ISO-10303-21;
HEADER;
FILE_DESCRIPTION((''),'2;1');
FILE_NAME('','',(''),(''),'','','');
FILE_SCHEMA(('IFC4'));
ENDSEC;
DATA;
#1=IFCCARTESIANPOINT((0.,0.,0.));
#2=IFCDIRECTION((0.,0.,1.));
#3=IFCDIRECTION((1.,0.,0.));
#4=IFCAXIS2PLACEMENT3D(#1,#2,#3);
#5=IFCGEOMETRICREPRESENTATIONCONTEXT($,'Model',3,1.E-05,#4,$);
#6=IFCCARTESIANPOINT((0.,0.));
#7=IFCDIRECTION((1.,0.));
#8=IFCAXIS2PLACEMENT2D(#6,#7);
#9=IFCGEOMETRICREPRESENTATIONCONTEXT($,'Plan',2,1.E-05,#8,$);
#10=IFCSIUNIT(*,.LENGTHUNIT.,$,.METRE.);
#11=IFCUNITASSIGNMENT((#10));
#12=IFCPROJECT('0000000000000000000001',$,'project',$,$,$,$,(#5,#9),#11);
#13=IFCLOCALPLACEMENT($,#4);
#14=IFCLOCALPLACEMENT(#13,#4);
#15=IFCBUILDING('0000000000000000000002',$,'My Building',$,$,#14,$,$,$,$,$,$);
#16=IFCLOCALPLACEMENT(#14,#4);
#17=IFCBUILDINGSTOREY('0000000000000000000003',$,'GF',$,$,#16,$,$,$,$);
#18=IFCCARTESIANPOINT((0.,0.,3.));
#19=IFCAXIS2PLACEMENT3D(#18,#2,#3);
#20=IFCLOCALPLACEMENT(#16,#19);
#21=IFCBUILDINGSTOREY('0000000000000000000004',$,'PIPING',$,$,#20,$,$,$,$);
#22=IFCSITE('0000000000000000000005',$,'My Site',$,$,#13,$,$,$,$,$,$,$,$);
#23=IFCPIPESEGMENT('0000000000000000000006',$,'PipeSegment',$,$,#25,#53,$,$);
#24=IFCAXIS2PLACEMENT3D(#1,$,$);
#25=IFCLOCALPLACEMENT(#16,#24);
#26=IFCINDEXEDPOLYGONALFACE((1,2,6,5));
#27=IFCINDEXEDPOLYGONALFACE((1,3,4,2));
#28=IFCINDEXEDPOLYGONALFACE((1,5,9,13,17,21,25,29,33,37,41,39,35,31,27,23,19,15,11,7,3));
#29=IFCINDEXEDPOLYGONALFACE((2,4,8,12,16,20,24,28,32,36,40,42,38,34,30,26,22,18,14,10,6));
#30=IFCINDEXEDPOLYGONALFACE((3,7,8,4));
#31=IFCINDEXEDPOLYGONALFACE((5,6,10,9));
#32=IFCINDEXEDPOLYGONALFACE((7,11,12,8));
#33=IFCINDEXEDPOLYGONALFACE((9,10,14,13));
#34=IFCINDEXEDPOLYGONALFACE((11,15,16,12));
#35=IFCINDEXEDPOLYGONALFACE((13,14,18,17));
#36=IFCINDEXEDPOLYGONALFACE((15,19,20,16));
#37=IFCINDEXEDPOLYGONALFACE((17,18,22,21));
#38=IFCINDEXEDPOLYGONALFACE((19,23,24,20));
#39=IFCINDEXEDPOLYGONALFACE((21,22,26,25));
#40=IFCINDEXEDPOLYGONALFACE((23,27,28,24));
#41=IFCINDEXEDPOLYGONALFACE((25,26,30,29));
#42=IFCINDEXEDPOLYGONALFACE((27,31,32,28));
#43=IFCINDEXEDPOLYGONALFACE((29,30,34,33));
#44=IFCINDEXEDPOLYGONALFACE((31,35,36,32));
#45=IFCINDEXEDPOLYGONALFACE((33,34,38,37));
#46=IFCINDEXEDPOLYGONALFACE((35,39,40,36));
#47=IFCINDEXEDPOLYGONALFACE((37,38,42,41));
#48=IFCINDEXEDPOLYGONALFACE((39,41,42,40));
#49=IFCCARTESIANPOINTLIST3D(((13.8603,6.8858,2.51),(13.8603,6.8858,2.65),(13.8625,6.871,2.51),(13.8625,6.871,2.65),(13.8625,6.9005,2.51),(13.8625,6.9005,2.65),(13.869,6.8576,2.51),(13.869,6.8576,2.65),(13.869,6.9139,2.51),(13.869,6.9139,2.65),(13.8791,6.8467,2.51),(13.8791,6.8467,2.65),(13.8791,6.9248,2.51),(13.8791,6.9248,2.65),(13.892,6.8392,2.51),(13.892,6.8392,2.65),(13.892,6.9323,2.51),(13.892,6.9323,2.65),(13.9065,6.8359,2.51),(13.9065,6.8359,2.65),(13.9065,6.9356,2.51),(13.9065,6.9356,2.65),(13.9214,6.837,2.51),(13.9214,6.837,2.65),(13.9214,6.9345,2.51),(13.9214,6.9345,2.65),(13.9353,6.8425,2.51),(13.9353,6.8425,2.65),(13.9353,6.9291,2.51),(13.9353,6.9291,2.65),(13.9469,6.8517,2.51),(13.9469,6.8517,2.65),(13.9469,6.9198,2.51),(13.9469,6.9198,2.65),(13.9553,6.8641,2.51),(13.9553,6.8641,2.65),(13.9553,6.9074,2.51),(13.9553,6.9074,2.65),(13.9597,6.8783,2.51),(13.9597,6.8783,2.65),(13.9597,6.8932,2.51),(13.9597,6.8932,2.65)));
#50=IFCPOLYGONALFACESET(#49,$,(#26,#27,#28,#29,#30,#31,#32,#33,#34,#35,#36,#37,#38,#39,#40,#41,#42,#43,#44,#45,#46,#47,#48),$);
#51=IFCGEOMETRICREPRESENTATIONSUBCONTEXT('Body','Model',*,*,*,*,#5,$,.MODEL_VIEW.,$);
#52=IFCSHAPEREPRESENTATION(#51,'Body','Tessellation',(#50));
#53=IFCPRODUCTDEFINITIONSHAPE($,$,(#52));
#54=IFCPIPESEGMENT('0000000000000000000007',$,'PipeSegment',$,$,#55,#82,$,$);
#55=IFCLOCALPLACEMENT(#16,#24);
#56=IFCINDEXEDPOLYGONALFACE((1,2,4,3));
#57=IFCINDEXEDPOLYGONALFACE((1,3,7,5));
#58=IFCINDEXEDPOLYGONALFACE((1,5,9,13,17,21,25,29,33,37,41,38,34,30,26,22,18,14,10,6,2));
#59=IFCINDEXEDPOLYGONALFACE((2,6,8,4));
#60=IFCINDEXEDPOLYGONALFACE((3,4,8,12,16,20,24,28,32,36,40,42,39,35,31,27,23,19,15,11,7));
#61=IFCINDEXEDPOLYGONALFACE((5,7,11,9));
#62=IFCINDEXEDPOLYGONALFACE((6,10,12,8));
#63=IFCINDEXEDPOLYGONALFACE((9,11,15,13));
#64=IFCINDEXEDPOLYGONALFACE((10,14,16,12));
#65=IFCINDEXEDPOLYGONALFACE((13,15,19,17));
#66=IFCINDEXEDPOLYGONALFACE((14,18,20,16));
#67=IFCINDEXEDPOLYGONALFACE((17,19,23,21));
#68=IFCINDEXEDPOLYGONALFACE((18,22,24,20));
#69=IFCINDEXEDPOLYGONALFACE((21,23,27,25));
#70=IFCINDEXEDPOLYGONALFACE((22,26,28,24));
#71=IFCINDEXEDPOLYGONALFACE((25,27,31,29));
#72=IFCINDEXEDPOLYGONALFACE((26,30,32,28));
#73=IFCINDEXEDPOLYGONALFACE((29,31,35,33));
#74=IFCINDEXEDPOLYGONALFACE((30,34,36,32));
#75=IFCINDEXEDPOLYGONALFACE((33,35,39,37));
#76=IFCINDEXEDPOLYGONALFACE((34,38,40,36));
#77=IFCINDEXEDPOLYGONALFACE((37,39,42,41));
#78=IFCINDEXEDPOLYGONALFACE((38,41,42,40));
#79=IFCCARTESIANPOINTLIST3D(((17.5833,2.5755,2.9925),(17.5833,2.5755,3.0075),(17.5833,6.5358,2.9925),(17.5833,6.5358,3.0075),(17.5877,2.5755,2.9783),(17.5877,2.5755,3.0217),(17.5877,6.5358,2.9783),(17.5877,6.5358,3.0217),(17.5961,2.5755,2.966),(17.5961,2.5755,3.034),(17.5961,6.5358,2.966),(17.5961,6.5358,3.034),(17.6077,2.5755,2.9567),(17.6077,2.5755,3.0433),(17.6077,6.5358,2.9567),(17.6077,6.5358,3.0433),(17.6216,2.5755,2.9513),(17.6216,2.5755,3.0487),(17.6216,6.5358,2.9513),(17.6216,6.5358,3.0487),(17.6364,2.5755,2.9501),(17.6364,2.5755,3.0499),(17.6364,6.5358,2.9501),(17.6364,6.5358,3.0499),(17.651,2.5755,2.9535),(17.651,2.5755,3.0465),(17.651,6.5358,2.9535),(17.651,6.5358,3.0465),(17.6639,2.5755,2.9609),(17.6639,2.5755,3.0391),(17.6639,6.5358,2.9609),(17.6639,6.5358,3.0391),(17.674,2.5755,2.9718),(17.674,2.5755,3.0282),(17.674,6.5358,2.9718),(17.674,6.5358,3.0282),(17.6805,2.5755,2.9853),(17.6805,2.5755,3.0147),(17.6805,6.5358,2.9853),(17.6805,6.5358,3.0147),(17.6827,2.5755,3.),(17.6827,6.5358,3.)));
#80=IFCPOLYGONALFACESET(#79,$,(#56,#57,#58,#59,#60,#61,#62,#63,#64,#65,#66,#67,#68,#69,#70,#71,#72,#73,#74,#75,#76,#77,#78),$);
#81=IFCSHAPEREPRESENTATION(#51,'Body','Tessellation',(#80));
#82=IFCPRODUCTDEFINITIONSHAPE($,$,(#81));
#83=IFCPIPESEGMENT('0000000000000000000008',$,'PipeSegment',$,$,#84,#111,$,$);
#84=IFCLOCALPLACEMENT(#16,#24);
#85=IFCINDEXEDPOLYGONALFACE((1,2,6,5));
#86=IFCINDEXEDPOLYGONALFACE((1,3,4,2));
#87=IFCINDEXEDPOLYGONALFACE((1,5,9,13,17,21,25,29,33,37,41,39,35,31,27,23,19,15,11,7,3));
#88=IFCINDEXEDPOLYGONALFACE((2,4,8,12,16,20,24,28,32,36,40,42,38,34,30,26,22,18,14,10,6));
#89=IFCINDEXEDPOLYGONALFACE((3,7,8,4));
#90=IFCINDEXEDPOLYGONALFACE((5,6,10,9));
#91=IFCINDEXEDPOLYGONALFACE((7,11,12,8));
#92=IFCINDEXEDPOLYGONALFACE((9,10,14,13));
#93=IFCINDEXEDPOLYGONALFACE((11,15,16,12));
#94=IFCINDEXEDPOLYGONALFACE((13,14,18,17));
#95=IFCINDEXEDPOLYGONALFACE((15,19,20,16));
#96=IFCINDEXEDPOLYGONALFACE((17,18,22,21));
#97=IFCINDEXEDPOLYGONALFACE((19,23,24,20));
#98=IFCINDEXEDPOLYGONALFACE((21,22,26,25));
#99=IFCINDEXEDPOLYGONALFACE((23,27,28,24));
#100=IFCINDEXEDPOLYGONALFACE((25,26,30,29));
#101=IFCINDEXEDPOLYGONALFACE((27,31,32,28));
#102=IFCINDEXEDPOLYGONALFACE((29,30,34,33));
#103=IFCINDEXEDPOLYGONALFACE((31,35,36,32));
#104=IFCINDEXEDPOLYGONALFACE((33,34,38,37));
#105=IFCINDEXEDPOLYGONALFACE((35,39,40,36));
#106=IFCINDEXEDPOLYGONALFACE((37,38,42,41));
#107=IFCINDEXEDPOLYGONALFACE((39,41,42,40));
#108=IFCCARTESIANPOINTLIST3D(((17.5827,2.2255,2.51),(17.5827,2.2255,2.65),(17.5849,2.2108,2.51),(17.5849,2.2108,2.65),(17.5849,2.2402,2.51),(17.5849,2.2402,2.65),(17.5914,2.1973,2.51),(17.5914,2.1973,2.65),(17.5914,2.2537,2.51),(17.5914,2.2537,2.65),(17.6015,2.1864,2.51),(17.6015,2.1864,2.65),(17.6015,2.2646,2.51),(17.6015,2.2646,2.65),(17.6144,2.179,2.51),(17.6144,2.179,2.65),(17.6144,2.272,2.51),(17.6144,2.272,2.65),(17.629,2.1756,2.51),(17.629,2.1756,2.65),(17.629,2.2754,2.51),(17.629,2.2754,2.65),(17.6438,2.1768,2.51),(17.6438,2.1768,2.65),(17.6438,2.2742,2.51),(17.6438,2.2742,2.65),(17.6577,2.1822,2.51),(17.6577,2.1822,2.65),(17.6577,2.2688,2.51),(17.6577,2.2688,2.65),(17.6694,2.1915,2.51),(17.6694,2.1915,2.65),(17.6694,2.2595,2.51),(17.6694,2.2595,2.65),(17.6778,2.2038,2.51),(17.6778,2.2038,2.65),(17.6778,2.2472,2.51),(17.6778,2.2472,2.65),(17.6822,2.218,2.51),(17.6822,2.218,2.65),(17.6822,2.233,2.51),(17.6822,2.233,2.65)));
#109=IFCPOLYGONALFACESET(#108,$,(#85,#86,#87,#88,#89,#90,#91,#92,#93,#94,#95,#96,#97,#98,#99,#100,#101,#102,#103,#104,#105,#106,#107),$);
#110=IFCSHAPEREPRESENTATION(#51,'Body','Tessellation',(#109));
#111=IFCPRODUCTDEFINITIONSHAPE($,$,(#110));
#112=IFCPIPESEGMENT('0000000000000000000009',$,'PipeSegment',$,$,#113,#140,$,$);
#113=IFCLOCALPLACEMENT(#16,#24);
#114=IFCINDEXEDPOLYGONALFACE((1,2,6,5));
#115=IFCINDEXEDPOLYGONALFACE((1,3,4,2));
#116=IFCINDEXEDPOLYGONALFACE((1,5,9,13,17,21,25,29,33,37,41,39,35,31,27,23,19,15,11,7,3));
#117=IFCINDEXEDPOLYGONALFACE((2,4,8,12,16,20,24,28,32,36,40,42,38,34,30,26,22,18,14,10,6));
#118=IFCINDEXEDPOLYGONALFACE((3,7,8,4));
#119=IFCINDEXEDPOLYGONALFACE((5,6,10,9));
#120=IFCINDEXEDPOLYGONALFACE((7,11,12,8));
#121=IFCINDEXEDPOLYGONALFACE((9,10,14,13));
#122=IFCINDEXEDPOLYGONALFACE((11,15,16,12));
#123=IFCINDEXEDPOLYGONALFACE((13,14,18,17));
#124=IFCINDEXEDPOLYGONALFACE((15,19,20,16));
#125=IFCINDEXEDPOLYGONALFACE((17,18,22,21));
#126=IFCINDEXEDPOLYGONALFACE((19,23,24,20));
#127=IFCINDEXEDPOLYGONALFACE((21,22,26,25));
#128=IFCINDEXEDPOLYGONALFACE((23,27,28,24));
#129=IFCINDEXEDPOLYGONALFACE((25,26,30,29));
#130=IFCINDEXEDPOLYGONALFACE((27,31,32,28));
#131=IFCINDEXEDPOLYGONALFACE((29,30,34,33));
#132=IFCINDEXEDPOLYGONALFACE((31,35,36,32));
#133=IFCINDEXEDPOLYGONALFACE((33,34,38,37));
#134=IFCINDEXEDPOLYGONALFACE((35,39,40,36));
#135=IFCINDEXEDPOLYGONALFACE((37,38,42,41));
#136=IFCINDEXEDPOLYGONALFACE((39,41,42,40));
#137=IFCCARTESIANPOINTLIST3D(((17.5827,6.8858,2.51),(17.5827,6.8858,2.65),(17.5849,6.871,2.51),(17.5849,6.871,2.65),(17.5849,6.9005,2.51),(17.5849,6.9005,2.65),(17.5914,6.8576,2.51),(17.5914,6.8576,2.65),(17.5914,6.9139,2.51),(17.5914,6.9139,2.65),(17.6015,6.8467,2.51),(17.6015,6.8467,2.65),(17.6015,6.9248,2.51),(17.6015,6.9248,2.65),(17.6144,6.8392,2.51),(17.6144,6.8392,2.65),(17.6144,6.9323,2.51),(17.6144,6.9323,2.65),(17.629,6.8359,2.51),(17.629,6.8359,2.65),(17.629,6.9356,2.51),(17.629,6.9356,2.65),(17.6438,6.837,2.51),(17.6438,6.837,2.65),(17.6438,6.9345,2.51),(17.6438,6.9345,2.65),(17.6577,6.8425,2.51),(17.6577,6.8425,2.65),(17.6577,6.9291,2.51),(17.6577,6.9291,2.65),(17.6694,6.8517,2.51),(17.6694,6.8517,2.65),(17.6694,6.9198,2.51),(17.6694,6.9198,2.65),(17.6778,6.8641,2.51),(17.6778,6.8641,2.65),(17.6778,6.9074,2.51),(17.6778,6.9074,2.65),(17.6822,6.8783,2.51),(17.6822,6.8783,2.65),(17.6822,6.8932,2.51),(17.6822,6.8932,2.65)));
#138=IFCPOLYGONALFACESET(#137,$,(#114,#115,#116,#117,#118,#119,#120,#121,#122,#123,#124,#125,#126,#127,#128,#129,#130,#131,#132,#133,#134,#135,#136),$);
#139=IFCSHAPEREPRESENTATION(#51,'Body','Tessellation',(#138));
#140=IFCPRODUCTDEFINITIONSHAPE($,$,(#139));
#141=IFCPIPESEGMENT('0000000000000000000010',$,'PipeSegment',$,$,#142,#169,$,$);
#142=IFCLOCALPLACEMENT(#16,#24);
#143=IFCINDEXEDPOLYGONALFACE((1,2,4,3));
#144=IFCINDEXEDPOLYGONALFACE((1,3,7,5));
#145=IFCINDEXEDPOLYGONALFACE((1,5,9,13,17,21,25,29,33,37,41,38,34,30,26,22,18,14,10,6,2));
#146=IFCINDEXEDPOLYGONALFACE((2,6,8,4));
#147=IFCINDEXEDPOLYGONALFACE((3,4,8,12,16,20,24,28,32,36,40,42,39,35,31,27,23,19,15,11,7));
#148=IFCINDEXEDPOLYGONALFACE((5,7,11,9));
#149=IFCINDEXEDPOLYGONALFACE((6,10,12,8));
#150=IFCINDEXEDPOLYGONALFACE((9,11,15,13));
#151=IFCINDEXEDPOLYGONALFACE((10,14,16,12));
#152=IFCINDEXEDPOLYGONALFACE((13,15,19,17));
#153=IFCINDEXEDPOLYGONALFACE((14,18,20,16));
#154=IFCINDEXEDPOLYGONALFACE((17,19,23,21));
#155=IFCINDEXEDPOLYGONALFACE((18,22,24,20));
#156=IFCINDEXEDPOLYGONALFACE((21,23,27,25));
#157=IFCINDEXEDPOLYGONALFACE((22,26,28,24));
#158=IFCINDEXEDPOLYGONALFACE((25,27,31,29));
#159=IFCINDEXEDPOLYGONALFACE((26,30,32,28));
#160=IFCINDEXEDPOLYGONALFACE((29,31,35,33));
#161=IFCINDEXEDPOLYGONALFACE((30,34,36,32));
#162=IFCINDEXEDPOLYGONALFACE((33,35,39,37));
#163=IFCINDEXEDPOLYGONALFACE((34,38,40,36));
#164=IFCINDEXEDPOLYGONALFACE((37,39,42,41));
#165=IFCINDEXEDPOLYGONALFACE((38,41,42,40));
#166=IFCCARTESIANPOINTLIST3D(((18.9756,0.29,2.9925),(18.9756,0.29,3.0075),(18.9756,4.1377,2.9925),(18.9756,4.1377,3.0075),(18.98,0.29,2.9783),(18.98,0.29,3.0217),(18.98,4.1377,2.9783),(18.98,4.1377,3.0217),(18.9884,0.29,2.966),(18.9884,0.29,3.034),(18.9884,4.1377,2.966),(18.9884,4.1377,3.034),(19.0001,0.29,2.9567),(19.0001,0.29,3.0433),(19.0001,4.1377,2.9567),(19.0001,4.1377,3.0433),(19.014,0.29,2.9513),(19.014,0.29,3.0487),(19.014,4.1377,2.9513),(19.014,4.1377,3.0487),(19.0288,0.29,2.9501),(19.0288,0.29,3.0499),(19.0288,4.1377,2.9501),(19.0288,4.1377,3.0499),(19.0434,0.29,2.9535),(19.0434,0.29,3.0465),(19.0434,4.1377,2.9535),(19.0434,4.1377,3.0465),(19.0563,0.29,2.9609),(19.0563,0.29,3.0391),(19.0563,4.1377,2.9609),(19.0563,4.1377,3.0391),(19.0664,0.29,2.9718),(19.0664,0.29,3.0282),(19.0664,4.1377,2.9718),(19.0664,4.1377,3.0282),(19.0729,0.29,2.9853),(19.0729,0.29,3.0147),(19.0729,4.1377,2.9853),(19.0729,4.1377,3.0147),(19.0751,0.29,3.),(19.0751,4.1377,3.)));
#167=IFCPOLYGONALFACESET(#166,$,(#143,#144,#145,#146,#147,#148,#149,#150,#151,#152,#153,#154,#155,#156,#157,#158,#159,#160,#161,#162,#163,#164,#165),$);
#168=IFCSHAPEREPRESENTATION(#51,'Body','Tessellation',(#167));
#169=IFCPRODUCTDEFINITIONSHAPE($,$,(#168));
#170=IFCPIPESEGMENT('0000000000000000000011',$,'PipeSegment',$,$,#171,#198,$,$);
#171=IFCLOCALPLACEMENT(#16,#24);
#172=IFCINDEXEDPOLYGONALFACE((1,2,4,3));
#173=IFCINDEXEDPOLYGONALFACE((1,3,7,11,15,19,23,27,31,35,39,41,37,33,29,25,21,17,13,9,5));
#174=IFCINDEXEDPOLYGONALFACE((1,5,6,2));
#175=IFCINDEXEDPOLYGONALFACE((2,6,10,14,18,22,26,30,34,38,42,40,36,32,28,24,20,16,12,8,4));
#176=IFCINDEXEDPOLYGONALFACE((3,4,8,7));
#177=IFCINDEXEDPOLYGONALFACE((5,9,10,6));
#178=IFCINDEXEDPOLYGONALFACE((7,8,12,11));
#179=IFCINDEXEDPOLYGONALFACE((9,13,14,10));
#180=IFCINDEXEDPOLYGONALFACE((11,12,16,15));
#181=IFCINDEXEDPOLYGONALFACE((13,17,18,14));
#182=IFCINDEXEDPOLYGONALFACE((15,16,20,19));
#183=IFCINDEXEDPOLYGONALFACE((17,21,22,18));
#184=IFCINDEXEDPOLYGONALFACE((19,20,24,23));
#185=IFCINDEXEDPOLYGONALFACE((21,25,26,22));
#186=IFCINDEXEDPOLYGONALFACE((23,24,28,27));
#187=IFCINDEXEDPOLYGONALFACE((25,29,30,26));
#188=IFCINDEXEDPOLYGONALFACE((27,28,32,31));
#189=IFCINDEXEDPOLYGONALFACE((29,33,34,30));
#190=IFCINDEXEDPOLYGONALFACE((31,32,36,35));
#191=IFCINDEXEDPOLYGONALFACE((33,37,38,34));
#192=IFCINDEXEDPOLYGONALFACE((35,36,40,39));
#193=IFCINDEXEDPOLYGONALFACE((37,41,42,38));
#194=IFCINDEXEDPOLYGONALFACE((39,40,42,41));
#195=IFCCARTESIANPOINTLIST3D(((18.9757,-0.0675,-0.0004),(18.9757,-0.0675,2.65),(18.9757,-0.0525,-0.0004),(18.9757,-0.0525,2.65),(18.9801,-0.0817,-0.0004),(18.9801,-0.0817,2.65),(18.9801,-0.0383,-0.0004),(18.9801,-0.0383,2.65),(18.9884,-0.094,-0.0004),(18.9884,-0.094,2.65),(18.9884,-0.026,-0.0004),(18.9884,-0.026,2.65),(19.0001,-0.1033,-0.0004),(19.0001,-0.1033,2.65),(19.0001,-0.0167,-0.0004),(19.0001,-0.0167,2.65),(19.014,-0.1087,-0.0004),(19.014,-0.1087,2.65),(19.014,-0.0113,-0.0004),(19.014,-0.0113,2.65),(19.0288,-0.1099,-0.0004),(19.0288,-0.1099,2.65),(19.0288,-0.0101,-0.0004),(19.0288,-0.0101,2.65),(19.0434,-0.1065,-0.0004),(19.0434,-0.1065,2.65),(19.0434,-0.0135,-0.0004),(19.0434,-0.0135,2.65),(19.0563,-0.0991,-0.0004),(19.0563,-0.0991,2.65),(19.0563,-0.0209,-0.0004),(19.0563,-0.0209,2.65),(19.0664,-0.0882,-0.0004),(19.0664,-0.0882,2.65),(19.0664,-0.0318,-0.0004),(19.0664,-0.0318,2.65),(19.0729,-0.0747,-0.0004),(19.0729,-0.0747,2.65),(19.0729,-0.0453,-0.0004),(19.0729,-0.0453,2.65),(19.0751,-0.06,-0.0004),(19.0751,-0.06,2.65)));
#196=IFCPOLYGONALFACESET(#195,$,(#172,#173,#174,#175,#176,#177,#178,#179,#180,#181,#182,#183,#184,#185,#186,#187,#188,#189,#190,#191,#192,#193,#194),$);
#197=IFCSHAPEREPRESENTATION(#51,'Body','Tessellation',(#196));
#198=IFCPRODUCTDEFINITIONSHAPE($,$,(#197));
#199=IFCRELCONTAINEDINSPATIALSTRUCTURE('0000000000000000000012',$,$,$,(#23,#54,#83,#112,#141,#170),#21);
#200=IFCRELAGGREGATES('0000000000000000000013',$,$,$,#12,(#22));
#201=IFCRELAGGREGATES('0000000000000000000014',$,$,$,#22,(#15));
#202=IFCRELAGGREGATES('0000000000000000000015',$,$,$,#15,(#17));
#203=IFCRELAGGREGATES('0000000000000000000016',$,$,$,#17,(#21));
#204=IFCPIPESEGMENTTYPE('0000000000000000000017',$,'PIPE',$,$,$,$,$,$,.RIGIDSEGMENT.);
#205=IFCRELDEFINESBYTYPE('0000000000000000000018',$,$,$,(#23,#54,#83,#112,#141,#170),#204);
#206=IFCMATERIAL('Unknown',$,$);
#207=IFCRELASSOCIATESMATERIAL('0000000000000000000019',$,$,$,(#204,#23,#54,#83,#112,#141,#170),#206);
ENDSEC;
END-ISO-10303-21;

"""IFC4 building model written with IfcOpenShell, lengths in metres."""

from ifc_helpers import new_model, si_unit, frame, origin_with_axes, origin_2d_with_axis, place, context, subcontext, project, spatial, circle, extrude, material, material_profile, profile_set, profile_usage, type_object, element, save


model = new_model("IFC4")

# Units and contexts
model_context = context("Model", 3, precision=1e-05, world=origin_with_axes())
plan_context = context("Plan", 2, precision=1e-05, world=origin_2d_with_axis())
body_context = subcontext(model_context, "Body", "Model", "MODEL_VIEW")
ifc_project = project(units=[si_unit("LENGTHUNIT", "METRE")], contexts=[model_context, plan_context])

# Site, building, storeys
site_placement = place(None, origin_with_axes())
site = spatial("IfcSite", under=ifc_project, at=site_placement, Name="My Site")
building_placement = place(site_placement, origin_with_axes())
building = spatial("IfcBuilding", under=site, at=building_placement, Name="My Building")
storey_1_placement = place(building_placement, origin_with_axes())
storey_1 = spatial("IfcBuildingStorey", under=building, at=storey_1_placement, Name="GF")
storey_2_placement = place(storey_1_placement, frame((0.0, 0.0, 3.0), z_axis=(0.0, 0.0, 1.0), x_axis=(1.0, 0.0, 0.0)))
storey_2 = spatial("IfcBuildingStorey", under=storey_1, at=storey_2_placement, Name="PIPING")

# Pipe segments
ifc_material = material(Name="Unknown")
ifc_material_profile = material_profile(ifc_material, circle(Radius=0.05))
ifc_profile_set = profile_set([ifc_material_profile])
pipe_segment_type = type_object("IfcPipeSegmentType", Name="PIPE", PredefinedType="RIGIDSEGMENT", material=ifc_profile_set)
ifc_profile_usage_1 = profile_usage(ifc_profile_set, cardinal=5)
pipe_segment_1_placement = place(storey_2_placement, frame((13.9103, 6.8858, -0.35), z_axis=(0.0, 0.0, -1.0), x_axis=(-1.0, 0.0, 0.0)))
element("IfcPipeSegment", 1, at=pipe_segment_1_placement, inside=storey_2, type_object=pipe_segment_type, material=ifc_profile_usage_1, Name="PipeSegment", context=body_context, shape_type="SweptSolid", body=[
    extrude(circle(Radius=0.05), origin_with_axes(), (0.0, 0.0, 1.0), 0.14),
])
ifc_profile_usage_2 = profile_usage(ifc_profile_set, cardinal=5)
pipe_segment_2_placement = place(storey_2_placement, frame((17.6327, 6.5358, 0.0), z_axis=(0.0, -1.0, 0.0), x_axis=(1.0, 0.0, 0.0)))
element("IfcPipeSegment", 2, at=pipe_segment_2_placement, inside=storey_2, type_object=pipe_segment_type, material=ifc_profile_usage_2, Name="PipeSegment", context=body_context, shape_type="SweptSolid", body=[
    extrude(circle(Radius=0.05), origin_with_axes(), (0.0, 0.0, 1.0), 3.9603),
])
ifc_profile_usage_3 = profile_usage(ifc_profile_set, cardinal=5)
pipe_segment_3_placement = place(storey_2_placement, frame((17.6327, 2.2255, -0.35), z_axis=(0.0, 0.0, -1.0), x_axis=(-1.0, 0.0, 0.0)))
element("IfcPipeSegment", 3, at=pipe_segment_3_placement, inside=storey_2, type_object=pipe_segment_type, material=ifc_profile_usage_3, Name="PipeSegment", context=body_context, shape_type="SweptSolid", body=[
    extrude(circle(Radius=0.05), origin_with_axes(), (0.0, 0.0, 1.0), 0.14),
])
ifc_profile_usage_4 = profile_usage(ifc_profile_set, cardinal=5)
pipe_segment_4_placement = place(storey_2_placement, frame((17.6327, 6.8858, -0.35), z_axis=(0.0, 0.0, -1.0), x_axis=(-1.0, 0.0, 0.0)))
element("IfcPipeSegment", 4, at=pipe_segment_4_placement, inside=storey_2, type_object=pipe_segment_type, material=ifc_profile_usage_4, Name="PipeSegment", context=body_context, shape_type="SweptSolid", body=[
    extrude(circle(Radius=0.05), origin_with_axes(), (0.0, 0.0, 1.0), 0.14),
])
ifc_profile_usage_5 = profile_usage(ifc_profile_set, cardinal=5)
pipe_segment_5_placement = place(storey_2_placement, frame((19.0251, 4.1377, 0.0), z_axis=(0.0, -1.0, 0.0), x_axis=(1.0, 0.0, 0.0)))
element("IfcPipeSegment", 5, at=pipe_segment_5_placement, inside=storey_2, type_object=pipe_segment_type, material=ifc_profile_usage_5, Name="PipeSegment", context=body_context, shape_type="SweptSolid", body=[
    extrude(circle(Radius=0.05), origin_with_axes(), (0.0, 0.0, 1.0), 3.8477),
])
ifc_profile_usage_6 = profile_usage(ifc_profile_set, cardinal=5)
pipe_segment_6_placement = place(storey_2_placement, frame((19.0251, -0.06, -0.35), z_axis=(0.0, 0.0, -1.0), x_axis=(1.0, 0.0, 0.0)))
element("IfcPipeSegment", 6, at=pipe_segment_6_placement, inside=storey_2, type_object=pipe_segment_type, material=ifc_profile_usage_6, Name="PipeSegment", context=body_context, shape_type="SweptSolid", body=[
    extrude(circle(Radius=0.05), origin_with_axes(), (0.0, 0.0, 1.0), 2.6504),
])

save(model, "model.ifc")
